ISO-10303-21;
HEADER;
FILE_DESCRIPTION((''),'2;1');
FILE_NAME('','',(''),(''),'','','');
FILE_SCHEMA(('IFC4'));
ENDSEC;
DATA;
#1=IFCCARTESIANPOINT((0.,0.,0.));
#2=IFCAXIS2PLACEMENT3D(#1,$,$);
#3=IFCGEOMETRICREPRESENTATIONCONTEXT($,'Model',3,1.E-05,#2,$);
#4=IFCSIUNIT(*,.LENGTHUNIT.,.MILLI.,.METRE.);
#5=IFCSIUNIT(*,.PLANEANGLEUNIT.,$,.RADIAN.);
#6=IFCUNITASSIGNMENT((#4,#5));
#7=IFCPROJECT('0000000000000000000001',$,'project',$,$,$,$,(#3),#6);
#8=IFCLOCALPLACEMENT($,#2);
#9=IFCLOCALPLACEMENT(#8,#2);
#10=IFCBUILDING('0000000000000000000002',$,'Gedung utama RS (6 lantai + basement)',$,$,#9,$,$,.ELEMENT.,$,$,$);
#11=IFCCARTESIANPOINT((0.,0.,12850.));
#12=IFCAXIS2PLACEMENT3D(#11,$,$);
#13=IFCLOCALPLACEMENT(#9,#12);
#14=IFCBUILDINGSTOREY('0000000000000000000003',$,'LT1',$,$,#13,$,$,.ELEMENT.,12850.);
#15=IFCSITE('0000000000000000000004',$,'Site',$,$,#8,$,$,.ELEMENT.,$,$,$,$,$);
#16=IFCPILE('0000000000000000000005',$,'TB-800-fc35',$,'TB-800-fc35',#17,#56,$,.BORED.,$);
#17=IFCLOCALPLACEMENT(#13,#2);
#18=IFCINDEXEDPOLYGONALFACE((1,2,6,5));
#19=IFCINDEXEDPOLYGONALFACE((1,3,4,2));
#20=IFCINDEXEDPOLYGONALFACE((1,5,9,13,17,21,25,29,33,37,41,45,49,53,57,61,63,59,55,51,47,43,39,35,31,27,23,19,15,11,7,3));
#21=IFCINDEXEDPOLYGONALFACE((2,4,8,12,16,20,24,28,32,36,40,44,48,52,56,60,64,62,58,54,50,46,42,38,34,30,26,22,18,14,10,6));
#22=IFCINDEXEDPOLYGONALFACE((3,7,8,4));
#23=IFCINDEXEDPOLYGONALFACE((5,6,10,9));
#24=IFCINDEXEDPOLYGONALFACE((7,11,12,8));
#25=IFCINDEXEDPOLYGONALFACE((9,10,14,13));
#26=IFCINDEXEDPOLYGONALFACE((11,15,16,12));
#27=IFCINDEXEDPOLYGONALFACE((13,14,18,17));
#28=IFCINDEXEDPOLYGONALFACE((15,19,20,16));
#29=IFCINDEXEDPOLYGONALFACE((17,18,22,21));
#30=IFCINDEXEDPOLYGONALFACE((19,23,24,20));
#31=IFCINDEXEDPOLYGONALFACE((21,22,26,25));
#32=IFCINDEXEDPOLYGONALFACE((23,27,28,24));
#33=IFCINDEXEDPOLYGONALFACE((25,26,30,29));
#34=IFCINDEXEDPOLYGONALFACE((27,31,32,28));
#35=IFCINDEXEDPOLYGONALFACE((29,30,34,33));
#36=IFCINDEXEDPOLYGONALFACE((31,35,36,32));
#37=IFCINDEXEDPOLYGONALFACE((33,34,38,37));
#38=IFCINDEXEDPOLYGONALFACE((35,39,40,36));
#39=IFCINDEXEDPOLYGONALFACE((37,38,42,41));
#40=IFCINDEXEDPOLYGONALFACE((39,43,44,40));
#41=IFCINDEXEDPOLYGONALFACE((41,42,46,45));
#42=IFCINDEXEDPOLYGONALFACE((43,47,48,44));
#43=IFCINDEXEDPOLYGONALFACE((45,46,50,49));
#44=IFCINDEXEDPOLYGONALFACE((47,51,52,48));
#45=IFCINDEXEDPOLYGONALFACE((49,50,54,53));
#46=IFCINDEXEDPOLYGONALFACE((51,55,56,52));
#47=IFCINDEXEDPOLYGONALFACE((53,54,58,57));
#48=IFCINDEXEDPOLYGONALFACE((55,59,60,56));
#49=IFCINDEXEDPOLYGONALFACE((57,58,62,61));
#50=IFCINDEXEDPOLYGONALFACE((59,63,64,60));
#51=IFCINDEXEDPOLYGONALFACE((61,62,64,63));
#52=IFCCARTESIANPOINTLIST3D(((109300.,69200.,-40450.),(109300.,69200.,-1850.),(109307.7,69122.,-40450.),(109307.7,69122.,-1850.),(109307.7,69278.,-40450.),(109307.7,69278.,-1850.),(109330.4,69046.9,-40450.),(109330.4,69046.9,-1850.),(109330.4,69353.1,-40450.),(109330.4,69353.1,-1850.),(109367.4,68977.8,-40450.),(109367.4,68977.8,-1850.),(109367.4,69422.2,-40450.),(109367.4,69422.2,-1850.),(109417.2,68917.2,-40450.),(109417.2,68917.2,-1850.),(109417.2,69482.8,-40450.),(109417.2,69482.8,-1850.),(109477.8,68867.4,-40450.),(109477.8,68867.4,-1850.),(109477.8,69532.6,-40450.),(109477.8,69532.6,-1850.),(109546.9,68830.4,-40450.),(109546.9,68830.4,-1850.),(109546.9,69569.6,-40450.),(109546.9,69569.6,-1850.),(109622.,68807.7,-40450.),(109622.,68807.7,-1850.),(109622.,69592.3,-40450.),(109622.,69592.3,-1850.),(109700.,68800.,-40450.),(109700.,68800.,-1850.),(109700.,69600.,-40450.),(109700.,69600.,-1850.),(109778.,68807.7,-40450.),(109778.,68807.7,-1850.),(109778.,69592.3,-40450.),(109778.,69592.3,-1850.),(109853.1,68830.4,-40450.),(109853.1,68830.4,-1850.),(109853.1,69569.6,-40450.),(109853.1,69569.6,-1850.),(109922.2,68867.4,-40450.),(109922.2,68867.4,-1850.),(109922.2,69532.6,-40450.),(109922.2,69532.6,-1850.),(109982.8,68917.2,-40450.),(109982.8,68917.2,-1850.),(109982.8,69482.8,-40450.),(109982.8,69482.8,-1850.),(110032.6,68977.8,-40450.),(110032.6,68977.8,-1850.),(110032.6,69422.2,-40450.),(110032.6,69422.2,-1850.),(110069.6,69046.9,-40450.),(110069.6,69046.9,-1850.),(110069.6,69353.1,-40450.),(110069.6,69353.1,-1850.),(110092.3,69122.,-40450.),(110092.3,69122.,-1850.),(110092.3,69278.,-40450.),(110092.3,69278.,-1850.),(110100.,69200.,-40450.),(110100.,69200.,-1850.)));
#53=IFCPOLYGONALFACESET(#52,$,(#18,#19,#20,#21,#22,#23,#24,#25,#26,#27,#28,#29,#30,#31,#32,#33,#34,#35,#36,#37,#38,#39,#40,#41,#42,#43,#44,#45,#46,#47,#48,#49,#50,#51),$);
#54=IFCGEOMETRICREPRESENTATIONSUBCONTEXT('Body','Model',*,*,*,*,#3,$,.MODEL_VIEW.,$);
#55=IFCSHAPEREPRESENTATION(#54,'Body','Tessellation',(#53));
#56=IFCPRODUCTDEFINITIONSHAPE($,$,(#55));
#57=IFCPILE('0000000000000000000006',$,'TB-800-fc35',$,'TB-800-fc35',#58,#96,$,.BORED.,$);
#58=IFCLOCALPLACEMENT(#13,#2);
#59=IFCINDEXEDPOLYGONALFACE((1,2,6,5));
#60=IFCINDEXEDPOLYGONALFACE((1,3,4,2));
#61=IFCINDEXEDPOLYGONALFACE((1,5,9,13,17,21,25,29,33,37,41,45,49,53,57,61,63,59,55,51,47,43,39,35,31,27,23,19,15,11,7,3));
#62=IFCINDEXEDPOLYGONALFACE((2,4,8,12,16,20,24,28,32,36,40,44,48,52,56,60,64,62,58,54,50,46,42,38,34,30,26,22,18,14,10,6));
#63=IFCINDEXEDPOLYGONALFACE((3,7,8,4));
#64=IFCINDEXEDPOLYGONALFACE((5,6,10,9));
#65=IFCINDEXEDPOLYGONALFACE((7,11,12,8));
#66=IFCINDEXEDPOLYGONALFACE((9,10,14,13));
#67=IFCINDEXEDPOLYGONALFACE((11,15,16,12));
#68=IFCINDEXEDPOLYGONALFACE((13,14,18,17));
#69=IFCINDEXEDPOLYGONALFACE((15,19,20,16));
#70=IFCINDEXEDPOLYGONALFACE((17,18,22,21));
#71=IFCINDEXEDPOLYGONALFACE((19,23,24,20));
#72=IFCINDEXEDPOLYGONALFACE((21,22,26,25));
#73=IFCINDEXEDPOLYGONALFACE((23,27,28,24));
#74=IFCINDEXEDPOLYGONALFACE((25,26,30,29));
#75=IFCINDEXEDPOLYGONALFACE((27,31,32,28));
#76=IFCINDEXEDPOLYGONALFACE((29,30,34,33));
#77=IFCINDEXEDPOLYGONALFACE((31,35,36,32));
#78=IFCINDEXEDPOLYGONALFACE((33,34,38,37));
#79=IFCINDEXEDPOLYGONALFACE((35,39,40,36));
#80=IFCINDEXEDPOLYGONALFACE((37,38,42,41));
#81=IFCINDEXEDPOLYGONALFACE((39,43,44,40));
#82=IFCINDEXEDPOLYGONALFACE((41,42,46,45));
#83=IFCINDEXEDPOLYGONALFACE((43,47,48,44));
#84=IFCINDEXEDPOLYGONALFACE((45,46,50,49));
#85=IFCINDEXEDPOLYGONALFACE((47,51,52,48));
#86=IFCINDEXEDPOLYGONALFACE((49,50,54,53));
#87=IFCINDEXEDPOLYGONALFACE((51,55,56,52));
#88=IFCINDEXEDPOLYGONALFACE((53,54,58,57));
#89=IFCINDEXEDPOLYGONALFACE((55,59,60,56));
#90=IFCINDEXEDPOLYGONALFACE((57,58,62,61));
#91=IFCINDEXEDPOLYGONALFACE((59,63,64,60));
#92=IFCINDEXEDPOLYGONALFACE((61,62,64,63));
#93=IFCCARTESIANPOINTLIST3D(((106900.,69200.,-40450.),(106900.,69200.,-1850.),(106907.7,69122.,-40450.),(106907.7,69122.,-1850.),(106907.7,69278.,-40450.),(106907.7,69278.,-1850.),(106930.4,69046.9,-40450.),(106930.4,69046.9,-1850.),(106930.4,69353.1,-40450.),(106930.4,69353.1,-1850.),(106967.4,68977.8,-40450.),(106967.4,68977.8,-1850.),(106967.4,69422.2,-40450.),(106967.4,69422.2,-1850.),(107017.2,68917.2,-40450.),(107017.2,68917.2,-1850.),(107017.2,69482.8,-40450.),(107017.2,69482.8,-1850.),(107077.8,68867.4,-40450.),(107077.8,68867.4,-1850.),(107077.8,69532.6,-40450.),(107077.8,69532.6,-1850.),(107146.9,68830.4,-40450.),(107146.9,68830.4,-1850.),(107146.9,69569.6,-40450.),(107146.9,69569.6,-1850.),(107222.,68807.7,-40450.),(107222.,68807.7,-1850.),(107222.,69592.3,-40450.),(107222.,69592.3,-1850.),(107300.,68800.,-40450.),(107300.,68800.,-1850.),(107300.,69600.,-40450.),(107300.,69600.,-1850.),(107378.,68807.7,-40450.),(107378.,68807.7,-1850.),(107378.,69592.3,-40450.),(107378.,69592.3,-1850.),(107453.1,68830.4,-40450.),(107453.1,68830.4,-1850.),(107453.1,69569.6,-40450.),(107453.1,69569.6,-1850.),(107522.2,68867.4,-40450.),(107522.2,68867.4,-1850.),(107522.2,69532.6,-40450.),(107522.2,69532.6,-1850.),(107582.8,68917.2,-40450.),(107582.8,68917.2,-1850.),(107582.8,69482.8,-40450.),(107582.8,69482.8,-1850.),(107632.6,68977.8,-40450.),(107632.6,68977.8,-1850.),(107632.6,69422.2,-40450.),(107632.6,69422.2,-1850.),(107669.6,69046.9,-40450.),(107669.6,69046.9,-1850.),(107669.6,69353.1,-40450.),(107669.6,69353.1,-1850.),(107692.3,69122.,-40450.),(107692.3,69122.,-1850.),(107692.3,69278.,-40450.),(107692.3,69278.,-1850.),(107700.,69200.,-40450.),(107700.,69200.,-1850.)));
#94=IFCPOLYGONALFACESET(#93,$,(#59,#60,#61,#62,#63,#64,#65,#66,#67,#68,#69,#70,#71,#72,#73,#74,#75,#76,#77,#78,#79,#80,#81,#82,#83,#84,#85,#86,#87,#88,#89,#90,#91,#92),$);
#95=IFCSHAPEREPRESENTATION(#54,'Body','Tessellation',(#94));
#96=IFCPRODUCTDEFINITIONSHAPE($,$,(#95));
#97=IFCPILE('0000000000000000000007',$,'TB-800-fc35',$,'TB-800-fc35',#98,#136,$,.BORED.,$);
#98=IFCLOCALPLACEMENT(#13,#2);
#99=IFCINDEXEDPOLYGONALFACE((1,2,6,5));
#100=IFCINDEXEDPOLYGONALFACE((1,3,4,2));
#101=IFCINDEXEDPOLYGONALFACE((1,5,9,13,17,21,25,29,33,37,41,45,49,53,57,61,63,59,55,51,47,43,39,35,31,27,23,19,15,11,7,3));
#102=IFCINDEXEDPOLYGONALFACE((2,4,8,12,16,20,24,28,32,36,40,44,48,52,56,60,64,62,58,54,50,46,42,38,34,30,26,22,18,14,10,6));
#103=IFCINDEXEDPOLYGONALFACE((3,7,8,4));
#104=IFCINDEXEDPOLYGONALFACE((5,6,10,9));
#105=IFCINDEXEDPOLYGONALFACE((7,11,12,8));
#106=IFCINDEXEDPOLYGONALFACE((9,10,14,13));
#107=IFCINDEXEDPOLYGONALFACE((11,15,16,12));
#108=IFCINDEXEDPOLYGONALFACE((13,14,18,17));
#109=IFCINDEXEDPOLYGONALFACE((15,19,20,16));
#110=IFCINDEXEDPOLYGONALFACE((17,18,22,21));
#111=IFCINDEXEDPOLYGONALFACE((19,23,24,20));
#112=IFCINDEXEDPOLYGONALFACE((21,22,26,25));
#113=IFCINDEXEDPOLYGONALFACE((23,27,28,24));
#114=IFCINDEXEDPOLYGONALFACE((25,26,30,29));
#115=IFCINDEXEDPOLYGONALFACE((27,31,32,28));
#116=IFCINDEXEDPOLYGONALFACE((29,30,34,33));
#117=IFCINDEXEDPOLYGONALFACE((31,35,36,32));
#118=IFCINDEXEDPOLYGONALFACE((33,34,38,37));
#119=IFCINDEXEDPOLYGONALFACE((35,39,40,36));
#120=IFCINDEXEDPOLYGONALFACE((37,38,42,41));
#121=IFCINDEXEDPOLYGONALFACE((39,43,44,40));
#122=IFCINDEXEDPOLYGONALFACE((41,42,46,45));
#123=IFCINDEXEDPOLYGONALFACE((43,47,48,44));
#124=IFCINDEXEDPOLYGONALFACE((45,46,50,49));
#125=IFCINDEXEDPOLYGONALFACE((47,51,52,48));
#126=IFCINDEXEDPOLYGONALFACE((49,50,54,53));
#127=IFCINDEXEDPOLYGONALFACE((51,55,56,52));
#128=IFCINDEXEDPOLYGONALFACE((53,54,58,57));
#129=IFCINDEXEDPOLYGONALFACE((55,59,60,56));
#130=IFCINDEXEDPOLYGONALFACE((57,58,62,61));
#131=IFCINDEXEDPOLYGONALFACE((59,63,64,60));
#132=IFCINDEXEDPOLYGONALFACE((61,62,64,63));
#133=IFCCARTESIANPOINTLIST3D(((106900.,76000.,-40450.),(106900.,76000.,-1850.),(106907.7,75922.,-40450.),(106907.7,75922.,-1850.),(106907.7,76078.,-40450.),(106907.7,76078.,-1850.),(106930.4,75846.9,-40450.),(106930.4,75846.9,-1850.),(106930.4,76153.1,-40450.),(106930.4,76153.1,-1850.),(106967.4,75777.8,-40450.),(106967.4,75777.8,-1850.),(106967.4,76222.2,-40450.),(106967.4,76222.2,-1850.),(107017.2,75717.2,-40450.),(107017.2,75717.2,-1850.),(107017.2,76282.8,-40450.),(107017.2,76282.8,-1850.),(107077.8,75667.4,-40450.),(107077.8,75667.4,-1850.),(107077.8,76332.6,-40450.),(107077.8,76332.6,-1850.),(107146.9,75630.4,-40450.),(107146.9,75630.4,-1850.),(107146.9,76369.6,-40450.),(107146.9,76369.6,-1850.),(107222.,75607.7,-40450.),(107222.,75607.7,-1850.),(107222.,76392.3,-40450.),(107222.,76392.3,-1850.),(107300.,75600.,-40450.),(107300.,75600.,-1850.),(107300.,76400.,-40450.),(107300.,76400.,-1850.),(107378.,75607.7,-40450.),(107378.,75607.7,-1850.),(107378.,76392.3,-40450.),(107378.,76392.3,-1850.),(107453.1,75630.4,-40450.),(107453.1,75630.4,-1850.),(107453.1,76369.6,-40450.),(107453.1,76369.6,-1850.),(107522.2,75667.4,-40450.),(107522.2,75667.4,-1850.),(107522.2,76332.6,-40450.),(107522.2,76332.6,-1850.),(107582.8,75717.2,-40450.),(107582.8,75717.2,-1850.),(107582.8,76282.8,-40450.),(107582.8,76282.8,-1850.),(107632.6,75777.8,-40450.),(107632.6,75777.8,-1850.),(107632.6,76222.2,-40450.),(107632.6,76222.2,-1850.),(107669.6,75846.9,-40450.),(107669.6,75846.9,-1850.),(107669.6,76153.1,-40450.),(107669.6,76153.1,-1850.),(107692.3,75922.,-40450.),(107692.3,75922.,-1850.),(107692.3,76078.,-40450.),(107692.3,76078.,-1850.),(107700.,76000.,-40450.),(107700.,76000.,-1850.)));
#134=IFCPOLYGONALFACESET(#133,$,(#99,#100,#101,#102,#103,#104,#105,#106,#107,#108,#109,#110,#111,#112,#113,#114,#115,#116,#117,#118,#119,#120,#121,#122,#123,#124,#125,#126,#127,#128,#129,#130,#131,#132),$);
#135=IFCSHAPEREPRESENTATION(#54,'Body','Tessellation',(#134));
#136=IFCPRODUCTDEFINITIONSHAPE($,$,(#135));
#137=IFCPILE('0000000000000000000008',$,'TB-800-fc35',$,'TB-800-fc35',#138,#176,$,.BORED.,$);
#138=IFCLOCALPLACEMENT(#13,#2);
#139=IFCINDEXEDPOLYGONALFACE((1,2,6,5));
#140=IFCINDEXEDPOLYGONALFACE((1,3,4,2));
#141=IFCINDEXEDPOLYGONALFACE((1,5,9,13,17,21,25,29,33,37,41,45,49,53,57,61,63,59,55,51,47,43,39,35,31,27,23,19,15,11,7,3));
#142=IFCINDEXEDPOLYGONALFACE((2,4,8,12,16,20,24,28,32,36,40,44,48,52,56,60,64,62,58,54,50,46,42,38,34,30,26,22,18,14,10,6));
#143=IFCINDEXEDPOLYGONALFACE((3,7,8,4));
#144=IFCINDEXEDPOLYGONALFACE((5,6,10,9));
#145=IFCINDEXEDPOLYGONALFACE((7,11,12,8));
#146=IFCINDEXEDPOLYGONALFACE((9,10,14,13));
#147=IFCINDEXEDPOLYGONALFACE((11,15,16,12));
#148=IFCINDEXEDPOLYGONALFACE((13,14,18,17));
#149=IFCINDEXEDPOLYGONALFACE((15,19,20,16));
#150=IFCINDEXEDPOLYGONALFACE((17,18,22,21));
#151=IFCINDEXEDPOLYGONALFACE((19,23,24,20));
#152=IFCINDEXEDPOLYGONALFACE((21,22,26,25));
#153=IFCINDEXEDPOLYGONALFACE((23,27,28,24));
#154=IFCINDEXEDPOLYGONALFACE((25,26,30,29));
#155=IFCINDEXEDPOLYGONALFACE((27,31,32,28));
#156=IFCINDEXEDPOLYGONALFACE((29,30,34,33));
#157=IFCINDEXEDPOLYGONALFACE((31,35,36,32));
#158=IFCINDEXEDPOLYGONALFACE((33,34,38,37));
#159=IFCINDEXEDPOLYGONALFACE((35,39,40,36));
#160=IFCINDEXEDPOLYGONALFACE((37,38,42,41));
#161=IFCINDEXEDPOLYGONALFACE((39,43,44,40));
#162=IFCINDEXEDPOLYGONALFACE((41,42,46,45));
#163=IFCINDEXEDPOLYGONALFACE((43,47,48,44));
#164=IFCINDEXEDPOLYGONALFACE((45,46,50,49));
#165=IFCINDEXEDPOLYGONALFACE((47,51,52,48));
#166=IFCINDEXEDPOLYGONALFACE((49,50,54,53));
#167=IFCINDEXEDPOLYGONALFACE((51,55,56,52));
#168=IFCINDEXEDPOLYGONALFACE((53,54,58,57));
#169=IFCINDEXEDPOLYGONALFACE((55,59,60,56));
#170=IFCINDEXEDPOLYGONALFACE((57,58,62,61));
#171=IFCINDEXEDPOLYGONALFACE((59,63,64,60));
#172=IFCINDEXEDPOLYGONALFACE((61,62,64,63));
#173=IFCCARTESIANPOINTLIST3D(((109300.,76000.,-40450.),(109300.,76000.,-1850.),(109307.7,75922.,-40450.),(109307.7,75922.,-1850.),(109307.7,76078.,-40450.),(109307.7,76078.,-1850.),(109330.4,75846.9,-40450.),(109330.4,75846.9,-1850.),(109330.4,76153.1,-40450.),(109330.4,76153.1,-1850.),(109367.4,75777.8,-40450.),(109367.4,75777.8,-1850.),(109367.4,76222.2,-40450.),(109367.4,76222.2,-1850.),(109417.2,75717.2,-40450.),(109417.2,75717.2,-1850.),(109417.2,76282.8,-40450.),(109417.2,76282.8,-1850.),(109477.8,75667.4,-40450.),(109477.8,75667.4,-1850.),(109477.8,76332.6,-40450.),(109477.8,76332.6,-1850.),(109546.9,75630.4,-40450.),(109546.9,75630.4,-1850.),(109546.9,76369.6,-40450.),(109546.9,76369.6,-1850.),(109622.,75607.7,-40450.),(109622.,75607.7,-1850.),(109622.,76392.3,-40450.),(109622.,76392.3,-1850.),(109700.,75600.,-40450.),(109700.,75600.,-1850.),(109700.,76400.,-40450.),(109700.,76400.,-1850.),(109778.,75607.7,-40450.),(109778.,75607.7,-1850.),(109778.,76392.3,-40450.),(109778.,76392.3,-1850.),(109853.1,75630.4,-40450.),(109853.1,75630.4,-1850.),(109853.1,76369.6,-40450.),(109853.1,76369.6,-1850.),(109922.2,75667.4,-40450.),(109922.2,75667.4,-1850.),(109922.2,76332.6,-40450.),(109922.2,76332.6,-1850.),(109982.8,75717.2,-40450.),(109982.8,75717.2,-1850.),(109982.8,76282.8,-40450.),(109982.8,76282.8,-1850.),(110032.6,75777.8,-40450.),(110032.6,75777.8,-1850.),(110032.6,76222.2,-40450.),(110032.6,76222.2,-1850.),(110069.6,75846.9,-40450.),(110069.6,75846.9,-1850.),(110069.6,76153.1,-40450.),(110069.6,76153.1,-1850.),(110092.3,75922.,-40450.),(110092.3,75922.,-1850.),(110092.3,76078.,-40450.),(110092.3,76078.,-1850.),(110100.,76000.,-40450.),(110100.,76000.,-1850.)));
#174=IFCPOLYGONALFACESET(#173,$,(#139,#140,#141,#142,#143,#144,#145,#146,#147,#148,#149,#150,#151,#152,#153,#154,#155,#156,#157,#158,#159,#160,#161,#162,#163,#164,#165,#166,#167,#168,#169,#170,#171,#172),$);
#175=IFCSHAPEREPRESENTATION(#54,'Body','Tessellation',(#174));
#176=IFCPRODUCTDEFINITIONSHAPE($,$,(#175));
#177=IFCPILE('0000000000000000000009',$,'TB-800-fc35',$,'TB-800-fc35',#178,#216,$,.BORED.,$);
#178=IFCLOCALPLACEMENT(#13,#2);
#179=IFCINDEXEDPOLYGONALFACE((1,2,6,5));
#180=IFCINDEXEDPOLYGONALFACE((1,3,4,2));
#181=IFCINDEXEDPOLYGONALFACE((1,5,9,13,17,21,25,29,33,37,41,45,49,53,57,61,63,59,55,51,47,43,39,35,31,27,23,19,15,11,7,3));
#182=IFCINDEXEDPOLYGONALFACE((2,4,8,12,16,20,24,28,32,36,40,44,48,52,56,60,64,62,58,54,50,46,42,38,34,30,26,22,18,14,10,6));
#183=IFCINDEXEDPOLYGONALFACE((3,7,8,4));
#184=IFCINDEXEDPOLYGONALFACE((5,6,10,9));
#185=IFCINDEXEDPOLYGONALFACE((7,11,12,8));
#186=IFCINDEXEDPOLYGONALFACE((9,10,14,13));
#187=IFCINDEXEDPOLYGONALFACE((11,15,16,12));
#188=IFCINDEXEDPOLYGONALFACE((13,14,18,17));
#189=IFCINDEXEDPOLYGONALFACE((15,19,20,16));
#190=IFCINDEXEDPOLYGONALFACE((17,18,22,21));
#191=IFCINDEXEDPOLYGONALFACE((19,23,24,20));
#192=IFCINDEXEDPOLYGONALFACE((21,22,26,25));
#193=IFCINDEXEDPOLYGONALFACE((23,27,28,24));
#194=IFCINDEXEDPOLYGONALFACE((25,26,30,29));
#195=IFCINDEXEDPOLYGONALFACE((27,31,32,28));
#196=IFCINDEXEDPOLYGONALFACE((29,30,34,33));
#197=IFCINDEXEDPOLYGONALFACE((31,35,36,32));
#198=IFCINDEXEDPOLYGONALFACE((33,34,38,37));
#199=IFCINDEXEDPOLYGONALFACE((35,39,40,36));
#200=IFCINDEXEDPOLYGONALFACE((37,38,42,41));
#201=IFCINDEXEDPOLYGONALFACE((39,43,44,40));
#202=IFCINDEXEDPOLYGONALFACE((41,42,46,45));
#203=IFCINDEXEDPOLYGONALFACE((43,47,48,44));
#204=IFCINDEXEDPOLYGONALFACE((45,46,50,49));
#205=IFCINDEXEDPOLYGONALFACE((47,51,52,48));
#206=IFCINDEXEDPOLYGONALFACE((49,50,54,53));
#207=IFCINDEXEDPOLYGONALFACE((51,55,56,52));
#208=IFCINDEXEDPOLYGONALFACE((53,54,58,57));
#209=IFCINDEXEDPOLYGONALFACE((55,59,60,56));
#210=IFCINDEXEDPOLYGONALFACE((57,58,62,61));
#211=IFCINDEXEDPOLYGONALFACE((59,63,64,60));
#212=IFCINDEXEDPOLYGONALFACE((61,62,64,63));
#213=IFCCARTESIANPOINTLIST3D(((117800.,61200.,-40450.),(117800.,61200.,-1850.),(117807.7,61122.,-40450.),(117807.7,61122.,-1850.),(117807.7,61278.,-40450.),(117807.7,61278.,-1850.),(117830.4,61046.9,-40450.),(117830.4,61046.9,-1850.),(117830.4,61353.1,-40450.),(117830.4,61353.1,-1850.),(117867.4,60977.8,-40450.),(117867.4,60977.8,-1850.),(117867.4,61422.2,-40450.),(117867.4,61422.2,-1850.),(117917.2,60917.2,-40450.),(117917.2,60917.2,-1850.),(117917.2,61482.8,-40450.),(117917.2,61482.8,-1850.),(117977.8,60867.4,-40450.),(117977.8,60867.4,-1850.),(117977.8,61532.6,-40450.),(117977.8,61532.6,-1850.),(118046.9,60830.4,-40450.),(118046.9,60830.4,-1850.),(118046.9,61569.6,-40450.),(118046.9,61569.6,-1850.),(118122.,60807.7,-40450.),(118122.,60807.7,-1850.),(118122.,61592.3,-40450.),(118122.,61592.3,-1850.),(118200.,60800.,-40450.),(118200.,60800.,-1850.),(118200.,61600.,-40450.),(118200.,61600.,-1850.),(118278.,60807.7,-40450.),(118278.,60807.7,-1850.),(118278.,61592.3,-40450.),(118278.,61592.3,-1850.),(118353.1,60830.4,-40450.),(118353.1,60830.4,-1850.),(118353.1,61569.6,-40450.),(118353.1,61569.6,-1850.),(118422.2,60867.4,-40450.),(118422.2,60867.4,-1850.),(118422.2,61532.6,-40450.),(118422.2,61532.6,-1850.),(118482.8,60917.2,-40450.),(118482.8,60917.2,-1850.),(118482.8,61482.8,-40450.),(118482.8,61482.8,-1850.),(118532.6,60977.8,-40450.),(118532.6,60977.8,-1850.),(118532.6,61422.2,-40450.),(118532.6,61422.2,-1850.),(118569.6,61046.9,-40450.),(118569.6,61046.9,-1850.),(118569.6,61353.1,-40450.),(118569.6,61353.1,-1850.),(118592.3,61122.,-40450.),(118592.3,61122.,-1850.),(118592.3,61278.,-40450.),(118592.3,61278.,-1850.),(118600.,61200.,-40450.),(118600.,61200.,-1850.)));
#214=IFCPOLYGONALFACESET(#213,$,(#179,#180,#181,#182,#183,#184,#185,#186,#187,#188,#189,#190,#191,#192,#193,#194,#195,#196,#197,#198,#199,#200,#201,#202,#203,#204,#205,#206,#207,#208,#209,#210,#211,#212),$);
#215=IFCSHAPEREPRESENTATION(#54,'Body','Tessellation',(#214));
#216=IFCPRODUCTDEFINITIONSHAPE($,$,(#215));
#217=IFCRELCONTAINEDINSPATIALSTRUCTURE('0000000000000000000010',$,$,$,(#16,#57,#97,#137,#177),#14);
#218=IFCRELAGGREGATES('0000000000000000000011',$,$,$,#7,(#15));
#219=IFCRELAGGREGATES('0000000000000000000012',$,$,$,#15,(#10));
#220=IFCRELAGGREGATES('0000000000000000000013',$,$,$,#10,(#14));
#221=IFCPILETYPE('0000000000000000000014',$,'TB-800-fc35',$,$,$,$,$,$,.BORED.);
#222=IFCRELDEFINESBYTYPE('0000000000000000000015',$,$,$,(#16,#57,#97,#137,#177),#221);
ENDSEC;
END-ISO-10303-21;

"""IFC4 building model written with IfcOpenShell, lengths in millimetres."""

from ifc_helpers import new_model, si_unit, frame, origin, origin_2d, place, context, subcontext, project, spatial, circle, extrude, material_profile, profile_set, profile_usage, type_object, element, save


model = new_model("IFC4")

# Units and contexts
model_context = context("Model", 3, precision=1e-05, world=origin())
body_context = subcontext(model_context, "Body", "Model", "MODEL_VIEW")
ifc_project = project(units=[si_unit("LENGTHUNIT", "METRE", prefix="MILLI"), si_unit("PLANEANGLEUNIT", "RADIAN")], contexts=[model_context])

# Site, building, storey
site_placement = place(None, origin())
site = spatial("IfcSite", under=ifc_project, at=site_placement, Name="Site", CompositionType="ELEMENT")
building_placement = place(site_placement, origin())
building = spatial("IfcBuilding", under=site, at=building_placement, Name="Gedung utama RS (6 lantai + basement)", CompositionType="ELEMENT")
storey_placement = place(building_placement, frame((0.0, 0.0, 12850.0)))
storey = spatial("IfcBuildingStorey", under=building, at=storey_placement, Name="LT1", CompositionType="ELEMENT", Elevation=12850.0)

# Piles
ifc_material_profile = material_profile(None, circle(Radius=400.0, at=origin_2d()), Name="TB-800-fc35")
ifc_profile_set = profile_set([ifc_material_profile], Name="TB-800-fc35")
ifc_profile_usage = profile_usage(ifc_profile_set, cardinal=5)
pile_type = type_object("IfcPileType", Name="TB-800-fc35", PredefinedType="BORED", material=ifc_profile_set)
for number, where, z_axis, x_axis, name in (
    (1, (109700.0, 69200.0, -40450.0), (0.0, 0.0, 1.0), (1.0, 0.0, 0.0), "TB-800-fc35"),
    (2, (107300.0, 69200.0, -40450.0), (0.0, 0.0, 1.0), (1.0, 0.0, 0.0), "TB-800-fc35"),
    (3, (107300.0, 76000.0, -40450.0), (0.0, 0.0, 1.0), (1.0, 0.0, 0.0), "TB-800-fc35"),
    (4, (109700.0, 76000.0, -40450.0), (0.0, 0.0, 1.0), (1.0, 0.0, 0.0), "TB-800-fc35"),
    (5, (118200.0, 61200.0, -40450.0), (0.0, 0.0, 1.0), (1.0, 0.0, 0.0), "TB-800-fc35"),
):
    element("IfcPile", number, at=place(storey_placement, frame(where, z_axis=z_axis, x_axis=x_axis)), inside=storey, type_object=pile_type, material=ifc_profile_usage, Name=name, ObjectType="TB-800-fc35", PredefinedType="BORED", context=body_context, shape_type="SweptSolid", body=[
        extrude(circle(Radius=400.0, at=origin_2d()), origin(), (0.0, 0.0, 1.0), 38600.0),
    ])

save(model, "model.ifc")
